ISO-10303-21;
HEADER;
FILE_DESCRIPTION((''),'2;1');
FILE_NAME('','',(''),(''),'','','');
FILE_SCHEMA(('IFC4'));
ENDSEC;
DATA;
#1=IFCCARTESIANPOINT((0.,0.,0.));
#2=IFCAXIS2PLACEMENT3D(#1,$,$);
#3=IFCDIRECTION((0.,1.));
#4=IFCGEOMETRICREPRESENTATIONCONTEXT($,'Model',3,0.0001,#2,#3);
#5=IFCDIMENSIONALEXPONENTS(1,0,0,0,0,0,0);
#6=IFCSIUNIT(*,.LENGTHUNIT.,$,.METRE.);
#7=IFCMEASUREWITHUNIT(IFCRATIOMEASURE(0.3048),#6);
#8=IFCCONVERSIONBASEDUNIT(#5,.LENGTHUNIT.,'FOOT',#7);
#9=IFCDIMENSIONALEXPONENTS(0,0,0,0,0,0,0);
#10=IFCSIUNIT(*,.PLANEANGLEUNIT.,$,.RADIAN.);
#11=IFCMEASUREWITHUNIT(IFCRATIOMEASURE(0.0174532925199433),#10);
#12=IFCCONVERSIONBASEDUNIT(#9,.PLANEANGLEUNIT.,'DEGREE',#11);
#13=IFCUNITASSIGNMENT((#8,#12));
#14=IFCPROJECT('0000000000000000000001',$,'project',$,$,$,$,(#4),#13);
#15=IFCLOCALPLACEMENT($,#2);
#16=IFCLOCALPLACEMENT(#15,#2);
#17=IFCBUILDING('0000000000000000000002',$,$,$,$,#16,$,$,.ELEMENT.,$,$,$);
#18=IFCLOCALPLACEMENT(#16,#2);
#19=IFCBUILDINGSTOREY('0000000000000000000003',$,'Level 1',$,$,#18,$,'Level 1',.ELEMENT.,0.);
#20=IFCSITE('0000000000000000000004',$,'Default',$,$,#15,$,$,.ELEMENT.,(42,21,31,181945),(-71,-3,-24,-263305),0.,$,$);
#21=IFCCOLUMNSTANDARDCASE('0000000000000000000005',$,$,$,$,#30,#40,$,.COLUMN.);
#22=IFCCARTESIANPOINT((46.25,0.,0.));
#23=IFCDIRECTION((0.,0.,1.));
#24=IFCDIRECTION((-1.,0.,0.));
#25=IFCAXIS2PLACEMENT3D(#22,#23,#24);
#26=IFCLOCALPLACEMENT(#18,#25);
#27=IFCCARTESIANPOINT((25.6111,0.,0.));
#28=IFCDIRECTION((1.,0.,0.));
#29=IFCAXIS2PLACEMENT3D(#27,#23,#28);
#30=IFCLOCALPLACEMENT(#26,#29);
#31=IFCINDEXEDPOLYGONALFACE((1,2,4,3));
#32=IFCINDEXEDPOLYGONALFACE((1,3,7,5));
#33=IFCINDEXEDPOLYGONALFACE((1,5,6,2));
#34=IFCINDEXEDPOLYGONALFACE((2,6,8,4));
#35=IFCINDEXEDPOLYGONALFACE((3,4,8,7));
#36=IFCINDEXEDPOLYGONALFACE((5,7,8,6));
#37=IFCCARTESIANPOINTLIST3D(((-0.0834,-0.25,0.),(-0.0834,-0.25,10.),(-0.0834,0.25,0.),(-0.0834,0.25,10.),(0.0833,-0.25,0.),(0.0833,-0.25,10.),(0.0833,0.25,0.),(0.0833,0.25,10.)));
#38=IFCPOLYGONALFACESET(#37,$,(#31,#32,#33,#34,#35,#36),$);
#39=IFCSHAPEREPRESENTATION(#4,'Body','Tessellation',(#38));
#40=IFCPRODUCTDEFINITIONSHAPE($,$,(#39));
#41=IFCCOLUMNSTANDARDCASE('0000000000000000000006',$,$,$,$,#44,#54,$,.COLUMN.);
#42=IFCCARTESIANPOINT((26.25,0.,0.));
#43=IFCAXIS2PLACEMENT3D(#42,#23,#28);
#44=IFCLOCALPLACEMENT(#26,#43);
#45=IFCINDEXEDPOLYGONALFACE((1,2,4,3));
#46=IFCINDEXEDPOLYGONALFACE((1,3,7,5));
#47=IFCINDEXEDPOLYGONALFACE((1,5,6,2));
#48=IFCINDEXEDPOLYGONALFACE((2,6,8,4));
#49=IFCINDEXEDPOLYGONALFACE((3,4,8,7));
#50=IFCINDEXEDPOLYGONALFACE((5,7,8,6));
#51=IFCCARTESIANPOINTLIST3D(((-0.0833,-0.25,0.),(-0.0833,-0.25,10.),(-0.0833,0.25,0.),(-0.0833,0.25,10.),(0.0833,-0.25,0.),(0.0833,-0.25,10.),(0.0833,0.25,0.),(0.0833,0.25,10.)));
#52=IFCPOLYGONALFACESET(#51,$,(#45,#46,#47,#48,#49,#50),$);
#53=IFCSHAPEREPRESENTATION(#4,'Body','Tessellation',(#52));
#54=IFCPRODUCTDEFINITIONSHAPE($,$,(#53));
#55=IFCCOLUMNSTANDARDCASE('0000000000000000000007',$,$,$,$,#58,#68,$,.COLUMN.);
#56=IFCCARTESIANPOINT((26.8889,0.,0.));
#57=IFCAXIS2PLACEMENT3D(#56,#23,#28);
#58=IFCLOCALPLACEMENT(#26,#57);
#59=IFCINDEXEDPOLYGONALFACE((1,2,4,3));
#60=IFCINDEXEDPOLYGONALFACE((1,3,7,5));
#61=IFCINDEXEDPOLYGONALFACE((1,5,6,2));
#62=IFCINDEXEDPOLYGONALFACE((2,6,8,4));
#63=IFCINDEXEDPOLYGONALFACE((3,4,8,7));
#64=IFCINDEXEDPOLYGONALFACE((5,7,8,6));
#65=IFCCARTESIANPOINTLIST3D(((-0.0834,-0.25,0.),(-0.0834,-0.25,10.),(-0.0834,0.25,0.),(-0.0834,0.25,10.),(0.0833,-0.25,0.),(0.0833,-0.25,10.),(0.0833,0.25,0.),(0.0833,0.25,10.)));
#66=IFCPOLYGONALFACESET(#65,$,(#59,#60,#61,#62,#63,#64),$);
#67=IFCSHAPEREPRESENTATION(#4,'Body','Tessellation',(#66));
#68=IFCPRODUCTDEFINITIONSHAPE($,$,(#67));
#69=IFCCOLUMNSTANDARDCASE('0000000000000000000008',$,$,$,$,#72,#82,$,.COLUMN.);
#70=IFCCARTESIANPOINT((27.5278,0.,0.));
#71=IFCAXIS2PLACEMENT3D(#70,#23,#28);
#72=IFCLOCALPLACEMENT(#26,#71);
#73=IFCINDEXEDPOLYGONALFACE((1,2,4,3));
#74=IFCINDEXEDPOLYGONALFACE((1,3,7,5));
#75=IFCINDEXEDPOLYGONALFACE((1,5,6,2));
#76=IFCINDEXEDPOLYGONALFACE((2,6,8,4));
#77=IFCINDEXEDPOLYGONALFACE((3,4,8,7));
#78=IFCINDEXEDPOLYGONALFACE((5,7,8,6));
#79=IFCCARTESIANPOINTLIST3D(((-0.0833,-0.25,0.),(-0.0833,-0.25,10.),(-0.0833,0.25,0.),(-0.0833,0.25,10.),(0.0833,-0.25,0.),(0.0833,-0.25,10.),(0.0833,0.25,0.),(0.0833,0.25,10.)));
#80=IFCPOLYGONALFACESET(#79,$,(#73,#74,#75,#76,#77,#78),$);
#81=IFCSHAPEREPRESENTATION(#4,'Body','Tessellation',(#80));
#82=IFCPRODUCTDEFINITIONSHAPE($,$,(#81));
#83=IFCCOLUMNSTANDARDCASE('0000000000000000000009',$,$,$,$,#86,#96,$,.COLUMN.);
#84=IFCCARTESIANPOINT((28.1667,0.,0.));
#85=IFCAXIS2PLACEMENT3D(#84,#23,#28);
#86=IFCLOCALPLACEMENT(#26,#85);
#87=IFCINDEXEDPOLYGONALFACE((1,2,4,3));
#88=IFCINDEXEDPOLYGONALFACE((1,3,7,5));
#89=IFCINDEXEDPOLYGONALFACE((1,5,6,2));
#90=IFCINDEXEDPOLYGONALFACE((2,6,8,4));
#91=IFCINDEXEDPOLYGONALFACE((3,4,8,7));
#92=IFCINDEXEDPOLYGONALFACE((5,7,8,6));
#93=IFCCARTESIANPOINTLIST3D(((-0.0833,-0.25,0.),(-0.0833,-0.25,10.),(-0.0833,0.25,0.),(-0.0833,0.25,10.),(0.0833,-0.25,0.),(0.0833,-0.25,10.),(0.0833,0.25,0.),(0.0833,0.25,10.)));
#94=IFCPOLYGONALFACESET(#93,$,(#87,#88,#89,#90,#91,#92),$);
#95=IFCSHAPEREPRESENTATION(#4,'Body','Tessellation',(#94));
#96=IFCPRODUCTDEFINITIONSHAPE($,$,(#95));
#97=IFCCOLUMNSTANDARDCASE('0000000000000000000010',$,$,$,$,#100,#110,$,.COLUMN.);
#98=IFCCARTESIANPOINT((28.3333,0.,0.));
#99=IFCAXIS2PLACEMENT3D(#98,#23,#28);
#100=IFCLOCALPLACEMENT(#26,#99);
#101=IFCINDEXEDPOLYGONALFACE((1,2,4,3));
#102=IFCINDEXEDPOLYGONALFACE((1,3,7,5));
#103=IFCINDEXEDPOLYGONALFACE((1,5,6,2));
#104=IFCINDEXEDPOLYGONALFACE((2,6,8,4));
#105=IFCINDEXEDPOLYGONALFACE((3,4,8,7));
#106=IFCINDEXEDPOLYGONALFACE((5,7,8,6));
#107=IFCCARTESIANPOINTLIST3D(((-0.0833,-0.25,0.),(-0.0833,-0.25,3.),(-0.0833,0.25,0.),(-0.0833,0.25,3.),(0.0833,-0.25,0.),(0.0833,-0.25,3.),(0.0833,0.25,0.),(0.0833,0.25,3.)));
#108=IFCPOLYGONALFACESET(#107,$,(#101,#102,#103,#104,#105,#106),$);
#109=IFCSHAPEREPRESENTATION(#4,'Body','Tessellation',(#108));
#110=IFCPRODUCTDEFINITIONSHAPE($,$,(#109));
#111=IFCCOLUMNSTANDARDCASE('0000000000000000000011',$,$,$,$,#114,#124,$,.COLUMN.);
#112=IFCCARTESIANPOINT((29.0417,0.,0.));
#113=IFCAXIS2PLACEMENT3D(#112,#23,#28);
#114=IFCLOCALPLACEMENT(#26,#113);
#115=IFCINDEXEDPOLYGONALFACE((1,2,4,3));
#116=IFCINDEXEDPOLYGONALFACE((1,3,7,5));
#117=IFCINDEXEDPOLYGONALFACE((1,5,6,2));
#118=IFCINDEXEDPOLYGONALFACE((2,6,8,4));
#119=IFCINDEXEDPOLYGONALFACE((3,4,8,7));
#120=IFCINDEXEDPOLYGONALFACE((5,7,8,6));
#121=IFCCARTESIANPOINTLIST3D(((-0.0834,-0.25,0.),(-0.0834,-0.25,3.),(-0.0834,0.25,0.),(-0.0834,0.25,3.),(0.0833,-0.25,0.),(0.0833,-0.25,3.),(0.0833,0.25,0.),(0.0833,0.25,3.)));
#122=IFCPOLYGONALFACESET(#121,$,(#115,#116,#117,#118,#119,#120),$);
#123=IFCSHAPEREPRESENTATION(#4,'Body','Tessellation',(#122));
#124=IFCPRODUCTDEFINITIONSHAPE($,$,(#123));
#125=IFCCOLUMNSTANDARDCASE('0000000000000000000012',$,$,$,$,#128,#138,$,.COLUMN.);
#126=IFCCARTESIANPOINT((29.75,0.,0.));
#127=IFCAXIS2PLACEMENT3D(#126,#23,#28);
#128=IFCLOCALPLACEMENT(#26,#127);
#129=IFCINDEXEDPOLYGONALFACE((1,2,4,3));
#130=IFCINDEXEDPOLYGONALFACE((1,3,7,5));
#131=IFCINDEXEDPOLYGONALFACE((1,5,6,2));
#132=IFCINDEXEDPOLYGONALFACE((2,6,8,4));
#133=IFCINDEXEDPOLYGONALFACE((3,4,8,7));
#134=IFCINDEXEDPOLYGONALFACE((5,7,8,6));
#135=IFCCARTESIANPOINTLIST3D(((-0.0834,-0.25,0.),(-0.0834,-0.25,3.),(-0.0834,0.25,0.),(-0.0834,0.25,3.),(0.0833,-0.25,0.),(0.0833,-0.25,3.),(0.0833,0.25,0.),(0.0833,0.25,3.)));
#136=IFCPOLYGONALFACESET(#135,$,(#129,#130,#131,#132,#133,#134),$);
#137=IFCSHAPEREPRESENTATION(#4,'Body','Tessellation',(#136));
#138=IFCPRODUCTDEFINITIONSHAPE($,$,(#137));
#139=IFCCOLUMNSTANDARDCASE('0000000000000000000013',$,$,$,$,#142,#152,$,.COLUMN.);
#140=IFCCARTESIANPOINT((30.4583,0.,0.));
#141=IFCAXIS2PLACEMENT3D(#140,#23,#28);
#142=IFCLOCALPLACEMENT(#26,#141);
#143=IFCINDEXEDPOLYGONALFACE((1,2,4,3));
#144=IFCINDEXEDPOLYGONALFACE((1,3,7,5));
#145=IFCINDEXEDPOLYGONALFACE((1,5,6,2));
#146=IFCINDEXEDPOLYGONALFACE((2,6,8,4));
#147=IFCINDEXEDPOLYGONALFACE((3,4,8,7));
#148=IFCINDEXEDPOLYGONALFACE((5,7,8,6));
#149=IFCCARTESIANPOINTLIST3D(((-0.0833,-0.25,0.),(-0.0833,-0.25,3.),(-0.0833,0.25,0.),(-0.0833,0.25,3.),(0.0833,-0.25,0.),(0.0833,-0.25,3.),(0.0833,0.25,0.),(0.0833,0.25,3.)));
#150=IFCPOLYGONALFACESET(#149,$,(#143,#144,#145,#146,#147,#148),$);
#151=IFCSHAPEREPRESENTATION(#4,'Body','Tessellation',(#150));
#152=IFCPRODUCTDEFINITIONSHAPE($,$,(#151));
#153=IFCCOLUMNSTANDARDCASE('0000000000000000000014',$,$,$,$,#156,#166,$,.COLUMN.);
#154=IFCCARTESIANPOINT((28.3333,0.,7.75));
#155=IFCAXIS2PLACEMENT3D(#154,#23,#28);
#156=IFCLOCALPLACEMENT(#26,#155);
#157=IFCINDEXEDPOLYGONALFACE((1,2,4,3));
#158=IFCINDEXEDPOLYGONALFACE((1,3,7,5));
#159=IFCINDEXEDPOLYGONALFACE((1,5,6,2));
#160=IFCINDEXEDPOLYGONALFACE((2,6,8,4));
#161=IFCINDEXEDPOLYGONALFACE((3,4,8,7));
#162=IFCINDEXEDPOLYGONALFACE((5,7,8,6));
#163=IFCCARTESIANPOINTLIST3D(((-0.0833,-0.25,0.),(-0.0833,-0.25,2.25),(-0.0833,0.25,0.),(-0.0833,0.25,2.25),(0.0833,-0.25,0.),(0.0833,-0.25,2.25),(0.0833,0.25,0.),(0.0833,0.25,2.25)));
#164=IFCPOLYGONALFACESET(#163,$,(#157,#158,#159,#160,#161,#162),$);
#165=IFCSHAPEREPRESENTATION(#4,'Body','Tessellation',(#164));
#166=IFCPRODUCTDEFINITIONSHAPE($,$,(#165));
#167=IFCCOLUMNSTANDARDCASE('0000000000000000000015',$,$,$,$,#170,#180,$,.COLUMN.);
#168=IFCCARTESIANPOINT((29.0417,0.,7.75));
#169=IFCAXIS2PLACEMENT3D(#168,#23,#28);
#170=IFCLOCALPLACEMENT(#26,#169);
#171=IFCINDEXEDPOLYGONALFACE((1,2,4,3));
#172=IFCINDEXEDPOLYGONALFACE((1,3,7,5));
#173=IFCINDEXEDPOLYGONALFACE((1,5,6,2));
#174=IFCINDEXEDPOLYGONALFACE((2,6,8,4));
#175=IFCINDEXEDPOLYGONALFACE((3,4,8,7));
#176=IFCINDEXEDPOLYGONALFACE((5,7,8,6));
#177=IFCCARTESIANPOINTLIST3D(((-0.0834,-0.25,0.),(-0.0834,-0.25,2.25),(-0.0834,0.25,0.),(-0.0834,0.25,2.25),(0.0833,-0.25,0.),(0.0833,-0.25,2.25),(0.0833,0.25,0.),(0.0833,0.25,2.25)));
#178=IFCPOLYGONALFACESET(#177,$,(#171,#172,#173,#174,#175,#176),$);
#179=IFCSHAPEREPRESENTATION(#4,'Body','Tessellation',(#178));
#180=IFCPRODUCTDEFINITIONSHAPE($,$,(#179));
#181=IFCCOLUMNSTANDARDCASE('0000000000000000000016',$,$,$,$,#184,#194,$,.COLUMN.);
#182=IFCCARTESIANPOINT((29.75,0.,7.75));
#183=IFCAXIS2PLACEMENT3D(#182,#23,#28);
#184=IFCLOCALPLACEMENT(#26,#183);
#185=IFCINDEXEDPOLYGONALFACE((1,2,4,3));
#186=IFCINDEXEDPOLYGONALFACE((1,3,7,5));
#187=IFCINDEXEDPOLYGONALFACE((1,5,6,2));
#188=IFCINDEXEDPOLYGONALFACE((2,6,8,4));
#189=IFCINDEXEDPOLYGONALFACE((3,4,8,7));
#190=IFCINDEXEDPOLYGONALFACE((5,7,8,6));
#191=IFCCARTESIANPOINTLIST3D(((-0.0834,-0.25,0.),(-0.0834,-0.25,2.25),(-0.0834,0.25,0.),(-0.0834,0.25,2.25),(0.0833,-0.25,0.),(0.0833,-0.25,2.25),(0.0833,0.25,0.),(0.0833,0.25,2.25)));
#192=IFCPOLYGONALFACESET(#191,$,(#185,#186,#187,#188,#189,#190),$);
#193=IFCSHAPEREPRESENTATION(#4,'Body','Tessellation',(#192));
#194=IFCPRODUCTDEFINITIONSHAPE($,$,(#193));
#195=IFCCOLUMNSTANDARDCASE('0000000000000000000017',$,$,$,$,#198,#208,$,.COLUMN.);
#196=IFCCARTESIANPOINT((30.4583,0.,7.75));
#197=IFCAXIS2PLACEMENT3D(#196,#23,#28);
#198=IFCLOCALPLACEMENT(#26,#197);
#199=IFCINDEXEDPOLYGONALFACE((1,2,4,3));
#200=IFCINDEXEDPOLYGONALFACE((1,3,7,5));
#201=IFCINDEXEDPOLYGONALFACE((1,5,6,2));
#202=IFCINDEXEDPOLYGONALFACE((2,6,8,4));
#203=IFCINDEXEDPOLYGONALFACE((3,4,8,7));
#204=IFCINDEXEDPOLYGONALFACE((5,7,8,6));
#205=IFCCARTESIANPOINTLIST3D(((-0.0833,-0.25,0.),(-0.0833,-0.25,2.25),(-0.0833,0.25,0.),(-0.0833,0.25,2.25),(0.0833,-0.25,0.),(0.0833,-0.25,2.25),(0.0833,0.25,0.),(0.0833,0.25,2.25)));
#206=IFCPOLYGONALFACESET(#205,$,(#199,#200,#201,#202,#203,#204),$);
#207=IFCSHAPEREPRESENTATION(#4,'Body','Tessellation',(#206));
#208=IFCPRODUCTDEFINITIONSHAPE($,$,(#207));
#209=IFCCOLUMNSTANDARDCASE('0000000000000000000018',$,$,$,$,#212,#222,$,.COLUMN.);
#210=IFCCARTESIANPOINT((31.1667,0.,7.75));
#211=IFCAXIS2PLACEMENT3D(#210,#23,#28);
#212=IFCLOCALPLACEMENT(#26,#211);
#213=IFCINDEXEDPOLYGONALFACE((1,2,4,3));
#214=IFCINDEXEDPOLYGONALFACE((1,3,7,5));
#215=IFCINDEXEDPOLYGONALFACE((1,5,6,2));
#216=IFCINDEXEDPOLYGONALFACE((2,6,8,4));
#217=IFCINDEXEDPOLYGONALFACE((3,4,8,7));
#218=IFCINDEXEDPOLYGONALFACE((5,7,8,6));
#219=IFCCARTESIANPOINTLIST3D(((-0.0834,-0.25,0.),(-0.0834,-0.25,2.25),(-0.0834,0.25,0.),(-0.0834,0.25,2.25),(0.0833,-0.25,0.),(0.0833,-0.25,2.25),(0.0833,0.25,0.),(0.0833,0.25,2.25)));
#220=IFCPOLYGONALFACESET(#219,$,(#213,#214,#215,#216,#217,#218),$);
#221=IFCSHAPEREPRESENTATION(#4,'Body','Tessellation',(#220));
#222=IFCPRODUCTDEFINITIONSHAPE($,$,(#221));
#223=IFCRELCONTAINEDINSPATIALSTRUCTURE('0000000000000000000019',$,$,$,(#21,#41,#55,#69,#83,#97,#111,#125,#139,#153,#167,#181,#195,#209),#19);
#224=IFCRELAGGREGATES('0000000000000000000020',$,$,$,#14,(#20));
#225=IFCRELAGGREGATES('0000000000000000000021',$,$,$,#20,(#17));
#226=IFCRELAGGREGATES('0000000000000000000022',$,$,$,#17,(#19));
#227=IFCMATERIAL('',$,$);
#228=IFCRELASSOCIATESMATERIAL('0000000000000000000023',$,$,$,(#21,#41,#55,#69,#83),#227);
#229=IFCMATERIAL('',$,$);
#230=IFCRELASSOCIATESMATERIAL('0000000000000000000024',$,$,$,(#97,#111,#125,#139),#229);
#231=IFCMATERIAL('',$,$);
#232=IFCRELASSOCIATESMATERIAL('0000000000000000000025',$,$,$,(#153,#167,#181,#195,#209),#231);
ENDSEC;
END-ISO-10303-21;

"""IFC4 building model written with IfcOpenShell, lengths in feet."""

from ifc_helpers import new_model, entity, si_unit, converted_unit, direction, frame, origin, place, context, project, spatial, rectangle, extrude, material, element, save


model = new_model("IFC4")

# Units and contexts
model_context = context("Model", 3, precision=0.0001, world=origin(), true_north=direction((0.0, 1.0)))
ifc_project = project(units=[converted_unit("LENGTHUNIT", "FOOT", entity("IfcRatioMeasure", 0.3048), si_unit("LENGTHUNIT", "METRE"), dimensions=[1, 0, 0, 0, 0, 0, 0]), converted_unit("PLANEANGLEUNIT", "DEGREE", entity("IfcRatioMeasure", 0.0174532925199433), si_unit("PLANEANGLEUNIT", "RADIAN"), dimensions=[0, 0, 0, 0, 0, 0, 0])], contexts=[model_context])

# Site, building, storey
site_placement = place(None, origin())
site = spatial("IfcSite", under=ifc_project, at=site_placement, Name="Default", CompositionType="ELEMENT", RefLatitude=(42, 21, 31, 181945), RefLongitude=(-71, -3, -24, -263305), RefElevation=0.0)
building_placement = place(site_placement, origin())
building = spatial("IfcBuilding", under=site, at=building_placement, CompositionType="ELEMENT")
storey_placement = place(building_placement, origin())
storey = spatial("IfcBuildingStorey", under=building, at=storey_placement, Name="Level 1", LongName="Level 1", CompositionType="ELEMENT", Elevation=0.0)

# Columns
ifc_material_1 = material(Name="")
placement = place(storey_placement, frame((46.25, 0.0, 0.0), z_axis=(0.0, 0.0, 1.0), x_axis=(-1.0, 0.0, 0.0)))
for number, where, z_axis, x_axis in (
    (1, (25.6111, 0.0, 0.0), (0.0, 0.0, 1.0), (1.0, 0.0, 0.0)),
    (2, (26.25, 0.0, 0.0), (0.0, 0.0, 1.0), (1.0, 0.0, 0.0)),
    (3, (26.8889, 0.0, 0.0), (0.0, 0.0, 1.0), (1.0, 0.0, 0.0)),
    (4, (27.5278, 0.0, 0.0), (0.0, 0.0, 1.0), (1.0, 0.0, 0.0)),
    (5, (28.1667, 0.0, 0.0), (0.0, 0.0, 1.0), (1.0, 0.0, 0.0)),
):
    element("IfcColumnStandardCase", number, at=place(placement, frame(where, z_axis=z_axis, x_axis=x_axis)), inside=storey, material=ifc_material_1, PredefinedType="COLUMN", context=model_context, shape_type="SweptSolid", body=[
        extrude(rectangle(XDim=0.1667, YDim=0.5), origin(), (0.0, 0.0, 1.0), 10.0),
    ])
ifc_material_2 = material(Name="")
for number, where, z_axis, x_axis in (
    (6, (28.3333, 0.0, 0.0), (0.0, 0.0, 1.0), (1.0, 0.0, 0.0)),
    (7, (29.0417, 0.0, 0.0), (0.0, 0.0, 1.0), (1.0, 0.0, 0.0)),
    (8, (29.75, 0.0, 0.0), (0.0, 0.0, 1.0), (1.0, 0.0, 0.0)),
    (9, (30.4583, 0.0, 0.0), (0.0, 0.0, 1.0), (1.0, 0.0, 0.0)),
):
    element("IfcColumnStandardCase", number, at=place(placement, frame(where, z_axis=z_axis, x_axis=x_axis)), inside=storey, material=ifc_material_2, PredefinedType="COLUMN", context=model_context, shape_type="SweptSolid", body=[
        extrude(rectangle(XDim=0.1667, YDim=0.5), origin(), (0.0, 0.0, 1.0), 3.0),
    ])
ifc_material_3 = material(Name="")
for number, where, z_axis, x_axis in (
    (10, (28.3333, 0.0, 7.75), (0.0, 0.0, 1.0), (1.0, 0.0, 0.0)),
    (11, (29.0417, 0.0, 7.75), (0.0, 0.0, 1.0), (1.0, 0.0, 0.0)),
    (12, (29.75, 0.0, 7.75), (0.0, 0.0, 1.0), (1.0, 0.0, 0.0)),
    (13, (30.4583, 0.0, 7.75), (0.0, 0.0, 1.0), (1.0, 0.0, 0.0)),
    (14, (31.1667, 0.0, 7.75), (0.0, 0.0, 1.0), (1.0, 0.0, 0.0)),
):
    element("IfcColumnStandardCase", number, at=place(placement, frame(where, z_axis=z_axis, x_axis=x_axis)), inside=storey, material=ifc_material_3, PredefinedType="COLUMN", context=model_context, shape_type="SweptSolid", body=[
        extrude(rectangle(XDim=0.1667, YDim=0.5), origin(), (0.0, 0.0, 1.0), 2.25),
    ])

save(model, "model.ifc")
